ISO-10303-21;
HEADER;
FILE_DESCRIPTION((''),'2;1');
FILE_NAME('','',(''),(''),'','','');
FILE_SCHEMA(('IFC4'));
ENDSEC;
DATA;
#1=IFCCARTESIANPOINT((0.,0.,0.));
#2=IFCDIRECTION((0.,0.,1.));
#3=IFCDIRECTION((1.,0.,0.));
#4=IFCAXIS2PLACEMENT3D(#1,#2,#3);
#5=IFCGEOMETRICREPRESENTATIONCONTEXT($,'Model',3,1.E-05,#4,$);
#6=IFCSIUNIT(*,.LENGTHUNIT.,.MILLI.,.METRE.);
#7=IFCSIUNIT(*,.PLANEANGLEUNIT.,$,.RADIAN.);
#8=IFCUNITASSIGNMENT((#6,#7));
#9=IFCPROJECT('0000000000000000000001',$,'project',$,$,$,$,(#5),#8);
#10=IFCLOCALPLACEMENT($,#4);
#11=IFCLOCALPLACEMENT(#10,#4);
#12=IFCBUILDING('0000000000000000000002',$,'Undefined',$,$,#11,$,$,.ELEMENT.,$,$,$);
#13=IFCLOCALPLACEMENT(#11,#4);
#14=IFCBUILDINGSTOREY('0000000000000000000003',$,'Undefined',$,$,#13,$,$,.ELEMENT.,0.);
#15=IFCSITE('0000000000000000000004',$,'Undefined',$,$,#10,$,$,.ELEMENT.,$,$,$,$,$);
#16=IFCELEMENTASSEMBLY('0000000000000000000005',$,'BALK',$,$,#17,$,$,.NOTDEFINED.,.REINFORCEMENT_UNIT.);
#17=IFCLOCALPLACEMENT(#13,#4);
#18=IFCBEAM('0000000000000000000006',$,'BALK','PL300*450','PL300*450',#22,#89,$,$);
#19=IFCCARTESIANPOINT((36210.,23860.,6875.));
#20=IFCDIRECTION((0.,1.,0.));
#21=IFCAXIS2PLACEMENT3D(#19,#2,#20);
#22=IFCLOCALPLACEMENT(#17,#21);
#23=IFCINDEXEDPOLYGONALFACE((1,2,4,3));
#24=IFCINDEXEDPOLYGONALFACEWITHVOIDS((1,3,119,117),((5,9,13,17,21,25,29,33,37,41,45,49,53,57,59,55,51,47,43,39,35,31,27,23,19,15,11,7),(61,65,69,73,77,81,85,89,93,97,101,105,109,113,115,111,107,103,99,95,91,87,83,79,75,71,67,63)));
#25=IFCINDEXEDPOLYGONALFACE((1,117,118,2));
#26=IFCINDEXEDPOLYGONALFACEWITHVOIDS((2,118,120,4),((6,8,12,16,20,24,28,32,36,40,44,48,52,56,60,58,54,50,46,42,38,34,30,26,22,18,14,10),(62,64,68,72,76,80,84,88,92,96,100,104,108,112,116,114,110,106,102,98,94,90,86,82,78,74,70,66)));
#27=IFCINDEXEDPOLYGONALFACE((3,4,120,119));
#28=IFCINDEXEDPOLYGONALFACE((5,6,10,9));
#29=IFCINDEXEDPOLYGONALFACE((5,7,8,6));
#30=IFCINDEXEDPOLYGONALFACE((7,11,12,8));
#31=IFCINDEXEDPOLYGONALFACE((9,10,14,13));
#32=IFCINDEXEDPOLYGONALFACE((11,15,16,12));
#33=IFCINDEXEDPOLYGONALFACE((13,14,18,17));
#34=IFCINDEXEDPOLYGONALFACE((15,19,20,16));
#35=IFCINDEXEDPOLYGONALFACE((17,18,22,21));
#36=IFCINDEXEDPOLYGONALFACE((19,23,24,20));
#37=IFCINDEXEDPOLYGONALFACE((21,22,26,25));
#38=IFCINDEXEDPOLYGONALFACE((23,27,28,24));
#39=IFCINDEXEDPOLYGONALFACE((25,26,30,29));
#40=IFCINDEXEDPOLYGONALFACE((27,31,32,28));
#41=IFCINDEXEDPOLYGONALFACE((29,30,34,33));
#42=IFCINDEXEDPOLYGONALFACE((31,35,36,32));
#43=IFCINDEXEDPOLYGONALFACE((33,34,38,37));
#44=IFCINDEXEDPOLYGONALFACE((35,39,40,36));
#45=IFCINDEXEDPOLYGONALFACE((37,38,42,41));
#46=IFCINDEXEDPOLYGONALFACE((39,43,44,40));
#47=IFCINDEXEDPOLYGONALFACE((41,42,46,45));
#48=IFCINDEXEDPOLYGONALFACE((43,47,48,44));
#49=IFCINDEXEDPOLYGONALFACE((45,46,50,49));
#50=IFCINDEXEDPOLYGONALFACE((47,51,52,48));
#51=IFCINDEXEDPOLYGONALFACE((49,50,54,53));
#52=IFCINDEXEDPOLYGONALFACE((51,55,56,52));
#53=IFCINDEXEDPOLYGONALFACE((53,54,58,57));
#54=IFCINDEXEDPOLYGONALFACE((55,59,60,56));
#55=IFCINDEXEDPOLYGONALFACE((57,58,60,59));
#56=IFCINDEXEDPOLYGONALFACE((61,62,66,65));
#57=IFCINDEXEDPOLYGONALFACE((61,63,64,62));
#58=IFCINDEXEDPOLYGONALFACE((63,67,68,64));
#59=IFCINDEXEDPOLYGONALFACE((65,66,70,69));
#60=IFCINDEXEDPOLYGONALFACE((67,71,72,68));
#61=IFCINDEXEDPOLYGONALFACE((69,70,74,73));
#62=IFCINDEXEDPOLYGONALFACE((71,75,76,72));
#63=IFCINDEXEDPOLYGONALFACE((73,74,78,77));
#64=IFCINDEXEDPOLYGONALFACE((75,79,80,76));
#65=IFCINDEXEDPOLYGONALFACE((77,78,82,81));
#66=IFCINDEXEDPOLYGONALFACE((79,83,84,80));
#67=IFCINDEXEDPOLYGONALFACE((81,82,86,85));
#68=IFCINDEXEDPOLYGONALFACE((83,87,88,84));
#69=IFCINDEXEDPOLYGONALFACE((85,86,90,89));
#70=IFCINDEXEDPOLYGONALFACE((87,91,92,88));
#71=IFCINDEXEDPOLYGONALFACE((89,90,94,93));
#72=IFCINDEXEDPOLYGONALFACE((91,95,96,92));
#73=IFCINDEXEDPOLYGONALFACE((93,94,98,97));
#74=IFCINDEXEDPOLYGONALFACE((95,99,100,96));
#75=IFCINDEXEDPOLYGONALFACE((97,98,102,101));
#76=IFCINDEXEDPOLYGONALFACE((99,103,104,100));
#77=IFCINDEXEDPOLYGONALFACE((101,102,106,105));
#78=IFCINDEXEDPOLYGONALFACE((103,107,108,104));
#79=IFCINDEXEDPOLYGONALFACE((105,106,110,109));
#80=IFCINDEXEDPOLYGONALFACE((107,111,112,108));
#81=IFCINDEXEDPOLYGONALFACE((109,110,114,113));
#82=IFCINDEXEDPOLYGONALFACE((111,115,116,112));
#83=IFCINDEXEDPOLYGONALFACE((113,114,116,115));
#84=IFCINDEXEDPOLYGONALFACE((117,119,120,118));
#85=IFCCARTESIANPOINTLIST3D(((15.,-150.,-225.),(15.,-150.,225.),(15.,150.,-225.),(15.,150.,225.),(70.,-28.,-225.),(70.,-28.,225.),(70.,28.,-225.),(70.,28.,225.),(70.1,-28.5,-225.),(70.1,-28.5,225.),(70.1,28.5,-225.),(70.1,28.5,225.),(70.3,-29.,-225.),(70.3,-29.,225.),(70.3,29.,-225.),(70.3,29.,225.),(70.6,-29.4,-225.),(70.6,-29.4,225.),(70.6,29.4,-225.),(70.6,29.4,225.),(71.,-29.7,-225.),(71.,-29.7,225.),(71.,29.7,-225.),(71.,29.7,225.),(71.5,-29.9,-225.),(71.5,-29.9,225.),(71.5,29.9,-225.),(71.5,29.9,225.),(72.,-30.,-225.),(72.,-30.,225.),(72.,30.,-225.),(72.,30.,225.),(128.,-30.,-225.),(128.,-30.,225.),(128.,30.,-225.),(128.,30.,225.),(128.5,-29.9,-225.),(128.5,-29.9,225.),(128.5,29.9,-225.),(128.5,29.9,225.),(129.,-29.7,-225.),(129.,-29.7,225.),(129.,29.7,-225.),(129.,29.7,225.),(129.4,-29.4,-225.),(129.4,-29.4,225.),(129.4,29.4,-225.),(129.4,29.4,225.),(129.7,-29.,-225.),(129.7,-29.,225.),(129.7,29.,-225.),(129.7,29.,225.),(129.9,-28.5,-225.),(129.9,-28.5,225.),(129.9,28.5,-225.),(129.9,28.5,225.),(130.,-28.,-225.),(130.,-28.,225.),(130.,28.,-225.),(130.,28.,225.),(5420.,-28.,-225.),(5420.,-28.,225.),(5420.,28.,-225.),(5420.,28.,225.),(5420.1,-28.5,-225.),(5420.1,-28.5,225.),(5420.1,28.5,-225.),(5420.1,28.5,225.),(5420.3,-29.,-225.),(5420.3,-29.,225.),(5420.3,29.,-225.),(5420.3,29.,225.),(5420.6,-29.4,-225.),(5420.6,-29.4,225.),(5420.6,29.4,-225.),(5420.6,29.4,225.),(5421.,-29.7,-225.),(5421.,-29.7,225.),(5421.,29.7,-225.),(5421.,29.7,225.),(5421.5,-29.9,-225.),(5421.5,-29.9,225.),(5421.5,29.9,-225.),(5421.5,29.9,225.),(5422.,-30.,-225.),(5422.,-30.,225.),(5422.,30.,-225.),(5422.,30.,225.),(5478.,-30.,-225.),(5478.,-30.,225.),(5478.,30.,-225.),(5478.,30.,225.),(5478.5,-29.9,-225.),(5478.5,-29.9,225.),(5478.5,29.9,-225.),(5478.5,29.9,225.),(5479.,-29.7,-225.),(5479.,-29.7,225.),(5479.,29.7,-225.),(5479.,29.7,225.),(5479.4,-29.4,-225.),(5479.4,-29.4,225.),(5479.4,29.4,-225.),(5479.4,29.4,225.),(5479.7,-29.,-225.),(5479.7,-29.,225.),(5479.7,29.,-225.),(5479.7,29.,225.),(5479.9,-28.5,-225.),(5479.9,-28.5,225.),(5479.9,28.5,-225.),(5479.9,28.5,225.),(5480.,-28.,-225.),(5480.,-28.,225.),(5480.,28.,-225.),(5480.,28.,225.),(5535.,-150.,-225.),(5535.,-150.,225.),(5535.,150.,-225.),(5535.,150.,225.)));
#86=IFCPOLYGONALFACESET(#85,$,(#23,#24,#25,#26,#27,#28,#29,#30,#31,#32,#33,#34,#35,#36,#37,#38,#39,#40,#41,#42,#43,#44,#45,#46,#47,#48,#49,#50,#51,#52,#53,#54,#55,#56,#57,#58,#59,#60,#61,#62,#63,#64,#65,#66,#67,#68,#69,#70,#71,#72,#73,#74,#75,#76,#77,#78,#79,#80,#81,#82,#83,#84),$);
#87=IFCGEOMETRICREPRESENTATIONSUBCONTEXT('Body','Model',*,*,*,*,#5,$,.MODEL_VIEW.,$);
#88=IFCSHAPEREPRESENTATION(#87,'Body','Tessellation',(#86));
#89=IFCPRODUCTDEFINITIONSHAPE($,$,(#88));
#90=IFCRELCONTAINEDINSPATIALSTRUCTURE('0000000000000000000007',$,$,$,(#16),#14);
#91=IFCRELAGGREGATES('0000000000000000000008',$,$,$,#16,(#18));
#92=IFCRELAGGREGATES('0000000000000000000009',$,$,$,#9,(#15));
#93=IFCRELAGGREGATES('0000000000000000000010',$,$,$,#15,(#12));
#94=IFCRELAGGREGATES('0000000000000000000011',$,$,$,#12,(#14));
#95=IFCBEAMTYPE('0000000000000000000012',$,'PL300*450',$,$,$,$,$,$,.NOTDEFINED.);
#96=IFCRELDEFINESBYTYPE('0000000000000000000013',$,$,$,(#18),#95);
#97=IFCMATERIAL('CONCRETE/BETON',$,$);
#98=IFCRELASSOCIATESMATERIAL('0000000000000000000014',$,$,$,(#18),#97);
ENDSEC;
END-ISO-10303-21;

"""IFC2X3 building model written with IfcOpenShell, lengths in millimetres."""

from ifc_helpers import new_model, si_unit, frame, frame_2d, origin_with_axes, place, context, subcontext, project, spatial, rectangle, rounded_rectangle, extrude, boolean, halfspace, material, type_object, element, aggregate, save


model = new_model("IFC2X3")

# Units and contexts
model_context = context("Model", 3, precision=1e-05, world=origin_with_axes())
body_context = subcontext(model_context, "Body", "Model", "MODEL_VIEW")
ifc_project = project(units=[si_unit("LENGTHUNIT", "METRE", prefix="MILLI"), si_unit("PLANEANGLEUNIT", "RADIAN")], contexts=[model_context])

# Site, building, storey
site_placement = place(None, origin_with_axes())
site = spatial("IfcSite", under=ifc_project, at=site_placement, Name="Undefined", CompositionType="ELEMENT")
building_placement = place(site_placement, origin_with_axes())
building = spatial("IfcBuilding", under=site, at=building_placement, Name="Undefined", CompositionType="ELEMENT")
storey_placement = place(building_placement, origin_with_axes())
storey = spatial("IfcBuildingStorey", under=building, at=storey_placement, Name="Undefined", CompositionType="ELEMENT", Elevation=0.0)

# Element assembly
ifc_material_1 = material(Name="CONCRETE/BETON")
assembly_1_placement = place(storey_placement, origin_with_axes())
assembly_1 = element("IfcElementAssembly", 1, at=assembly_1_placement, inside=storey, Name="BALK", AssemblyPlace="NOTDEFINED", PredefinedType="REINFORCEMENT_UNIT")

# Beam
beam_type_1 = type_object("IfcBeamType", Name="PL300*450", PredefinedType="NOTDEFINED")
beam_1_placement = place(assembly_1_placement, frame((36210.0, 23860.0, 6875.0), z_axis=(0.0, 0.0, 1.0), x_axis=(0.0, 1.0, 0.0)))
beam_1 = element("IfcBeam", 2, at=beam_1_placement, type_object=beam_type_1, material=ifc_material_1, Name="BALK", Description="PL300*450", ObjectType="PL300*450", context=body_context, shape_type="CSG", body=[
    boolean("DIFFERENCE", boolean("DIFFERENCE", boolean("DIFFERENCE", boolean("DIFFERENCE", extrude(rectangle(XDim=300.0, YDim=450.0, at=frame_2d((0.0, 0.0), x_axis=(1.0, 0.0))), frame((5535.0, 0.0, 0.0), z_axis=(-1.0, 0.0, 0.0), x_axis=(0.0, -1.0, 0.0)), (0.0, 0.0, 1.0), 5520.0), extrude(rounded_rectangle(XDim=60.0, YDim=60.0, RoundingRadius=2.0, at=frame_2d((0.0, 0.0), x_axis=(1.0, 0.0))), frame((5450.0, 0.0, 275.0), z_axis=(0.0, 0.0, -1.0), x_axis=(-1.0, 0.0, 0.0)), (0.0, 0.0, 1.0), 508.0)), extrude(rounded_rectangle(XDim=60.0, YDim=60.0, RoundingRadius=2.0, at=frame_2d((0.0, 0.0), x_axis=(1.0, 0.0))), frame((100.0, 0.0, 275.0), z_axis=(0.0, 0.0, -1.0), x_axis=(-1.0, 0.0, 0.0)), (0.0, 0.0, 1.0), 508.0)), halfspace(frame((5535.0, 0.0, 1.0), z_axis=(1.0, 0.0, 0.0), x_axis=(0.0, 1.0, 0.0)), False)), halfspace(frame((15.0, 0.0, 10.0), z_axis=(1.0, 0.0, 0.0), x_axis=(0.0, 1.0, 0.0)), True)),
])
aggregate(assembly_1, [beam_1])

save(model, "model.ifc")
